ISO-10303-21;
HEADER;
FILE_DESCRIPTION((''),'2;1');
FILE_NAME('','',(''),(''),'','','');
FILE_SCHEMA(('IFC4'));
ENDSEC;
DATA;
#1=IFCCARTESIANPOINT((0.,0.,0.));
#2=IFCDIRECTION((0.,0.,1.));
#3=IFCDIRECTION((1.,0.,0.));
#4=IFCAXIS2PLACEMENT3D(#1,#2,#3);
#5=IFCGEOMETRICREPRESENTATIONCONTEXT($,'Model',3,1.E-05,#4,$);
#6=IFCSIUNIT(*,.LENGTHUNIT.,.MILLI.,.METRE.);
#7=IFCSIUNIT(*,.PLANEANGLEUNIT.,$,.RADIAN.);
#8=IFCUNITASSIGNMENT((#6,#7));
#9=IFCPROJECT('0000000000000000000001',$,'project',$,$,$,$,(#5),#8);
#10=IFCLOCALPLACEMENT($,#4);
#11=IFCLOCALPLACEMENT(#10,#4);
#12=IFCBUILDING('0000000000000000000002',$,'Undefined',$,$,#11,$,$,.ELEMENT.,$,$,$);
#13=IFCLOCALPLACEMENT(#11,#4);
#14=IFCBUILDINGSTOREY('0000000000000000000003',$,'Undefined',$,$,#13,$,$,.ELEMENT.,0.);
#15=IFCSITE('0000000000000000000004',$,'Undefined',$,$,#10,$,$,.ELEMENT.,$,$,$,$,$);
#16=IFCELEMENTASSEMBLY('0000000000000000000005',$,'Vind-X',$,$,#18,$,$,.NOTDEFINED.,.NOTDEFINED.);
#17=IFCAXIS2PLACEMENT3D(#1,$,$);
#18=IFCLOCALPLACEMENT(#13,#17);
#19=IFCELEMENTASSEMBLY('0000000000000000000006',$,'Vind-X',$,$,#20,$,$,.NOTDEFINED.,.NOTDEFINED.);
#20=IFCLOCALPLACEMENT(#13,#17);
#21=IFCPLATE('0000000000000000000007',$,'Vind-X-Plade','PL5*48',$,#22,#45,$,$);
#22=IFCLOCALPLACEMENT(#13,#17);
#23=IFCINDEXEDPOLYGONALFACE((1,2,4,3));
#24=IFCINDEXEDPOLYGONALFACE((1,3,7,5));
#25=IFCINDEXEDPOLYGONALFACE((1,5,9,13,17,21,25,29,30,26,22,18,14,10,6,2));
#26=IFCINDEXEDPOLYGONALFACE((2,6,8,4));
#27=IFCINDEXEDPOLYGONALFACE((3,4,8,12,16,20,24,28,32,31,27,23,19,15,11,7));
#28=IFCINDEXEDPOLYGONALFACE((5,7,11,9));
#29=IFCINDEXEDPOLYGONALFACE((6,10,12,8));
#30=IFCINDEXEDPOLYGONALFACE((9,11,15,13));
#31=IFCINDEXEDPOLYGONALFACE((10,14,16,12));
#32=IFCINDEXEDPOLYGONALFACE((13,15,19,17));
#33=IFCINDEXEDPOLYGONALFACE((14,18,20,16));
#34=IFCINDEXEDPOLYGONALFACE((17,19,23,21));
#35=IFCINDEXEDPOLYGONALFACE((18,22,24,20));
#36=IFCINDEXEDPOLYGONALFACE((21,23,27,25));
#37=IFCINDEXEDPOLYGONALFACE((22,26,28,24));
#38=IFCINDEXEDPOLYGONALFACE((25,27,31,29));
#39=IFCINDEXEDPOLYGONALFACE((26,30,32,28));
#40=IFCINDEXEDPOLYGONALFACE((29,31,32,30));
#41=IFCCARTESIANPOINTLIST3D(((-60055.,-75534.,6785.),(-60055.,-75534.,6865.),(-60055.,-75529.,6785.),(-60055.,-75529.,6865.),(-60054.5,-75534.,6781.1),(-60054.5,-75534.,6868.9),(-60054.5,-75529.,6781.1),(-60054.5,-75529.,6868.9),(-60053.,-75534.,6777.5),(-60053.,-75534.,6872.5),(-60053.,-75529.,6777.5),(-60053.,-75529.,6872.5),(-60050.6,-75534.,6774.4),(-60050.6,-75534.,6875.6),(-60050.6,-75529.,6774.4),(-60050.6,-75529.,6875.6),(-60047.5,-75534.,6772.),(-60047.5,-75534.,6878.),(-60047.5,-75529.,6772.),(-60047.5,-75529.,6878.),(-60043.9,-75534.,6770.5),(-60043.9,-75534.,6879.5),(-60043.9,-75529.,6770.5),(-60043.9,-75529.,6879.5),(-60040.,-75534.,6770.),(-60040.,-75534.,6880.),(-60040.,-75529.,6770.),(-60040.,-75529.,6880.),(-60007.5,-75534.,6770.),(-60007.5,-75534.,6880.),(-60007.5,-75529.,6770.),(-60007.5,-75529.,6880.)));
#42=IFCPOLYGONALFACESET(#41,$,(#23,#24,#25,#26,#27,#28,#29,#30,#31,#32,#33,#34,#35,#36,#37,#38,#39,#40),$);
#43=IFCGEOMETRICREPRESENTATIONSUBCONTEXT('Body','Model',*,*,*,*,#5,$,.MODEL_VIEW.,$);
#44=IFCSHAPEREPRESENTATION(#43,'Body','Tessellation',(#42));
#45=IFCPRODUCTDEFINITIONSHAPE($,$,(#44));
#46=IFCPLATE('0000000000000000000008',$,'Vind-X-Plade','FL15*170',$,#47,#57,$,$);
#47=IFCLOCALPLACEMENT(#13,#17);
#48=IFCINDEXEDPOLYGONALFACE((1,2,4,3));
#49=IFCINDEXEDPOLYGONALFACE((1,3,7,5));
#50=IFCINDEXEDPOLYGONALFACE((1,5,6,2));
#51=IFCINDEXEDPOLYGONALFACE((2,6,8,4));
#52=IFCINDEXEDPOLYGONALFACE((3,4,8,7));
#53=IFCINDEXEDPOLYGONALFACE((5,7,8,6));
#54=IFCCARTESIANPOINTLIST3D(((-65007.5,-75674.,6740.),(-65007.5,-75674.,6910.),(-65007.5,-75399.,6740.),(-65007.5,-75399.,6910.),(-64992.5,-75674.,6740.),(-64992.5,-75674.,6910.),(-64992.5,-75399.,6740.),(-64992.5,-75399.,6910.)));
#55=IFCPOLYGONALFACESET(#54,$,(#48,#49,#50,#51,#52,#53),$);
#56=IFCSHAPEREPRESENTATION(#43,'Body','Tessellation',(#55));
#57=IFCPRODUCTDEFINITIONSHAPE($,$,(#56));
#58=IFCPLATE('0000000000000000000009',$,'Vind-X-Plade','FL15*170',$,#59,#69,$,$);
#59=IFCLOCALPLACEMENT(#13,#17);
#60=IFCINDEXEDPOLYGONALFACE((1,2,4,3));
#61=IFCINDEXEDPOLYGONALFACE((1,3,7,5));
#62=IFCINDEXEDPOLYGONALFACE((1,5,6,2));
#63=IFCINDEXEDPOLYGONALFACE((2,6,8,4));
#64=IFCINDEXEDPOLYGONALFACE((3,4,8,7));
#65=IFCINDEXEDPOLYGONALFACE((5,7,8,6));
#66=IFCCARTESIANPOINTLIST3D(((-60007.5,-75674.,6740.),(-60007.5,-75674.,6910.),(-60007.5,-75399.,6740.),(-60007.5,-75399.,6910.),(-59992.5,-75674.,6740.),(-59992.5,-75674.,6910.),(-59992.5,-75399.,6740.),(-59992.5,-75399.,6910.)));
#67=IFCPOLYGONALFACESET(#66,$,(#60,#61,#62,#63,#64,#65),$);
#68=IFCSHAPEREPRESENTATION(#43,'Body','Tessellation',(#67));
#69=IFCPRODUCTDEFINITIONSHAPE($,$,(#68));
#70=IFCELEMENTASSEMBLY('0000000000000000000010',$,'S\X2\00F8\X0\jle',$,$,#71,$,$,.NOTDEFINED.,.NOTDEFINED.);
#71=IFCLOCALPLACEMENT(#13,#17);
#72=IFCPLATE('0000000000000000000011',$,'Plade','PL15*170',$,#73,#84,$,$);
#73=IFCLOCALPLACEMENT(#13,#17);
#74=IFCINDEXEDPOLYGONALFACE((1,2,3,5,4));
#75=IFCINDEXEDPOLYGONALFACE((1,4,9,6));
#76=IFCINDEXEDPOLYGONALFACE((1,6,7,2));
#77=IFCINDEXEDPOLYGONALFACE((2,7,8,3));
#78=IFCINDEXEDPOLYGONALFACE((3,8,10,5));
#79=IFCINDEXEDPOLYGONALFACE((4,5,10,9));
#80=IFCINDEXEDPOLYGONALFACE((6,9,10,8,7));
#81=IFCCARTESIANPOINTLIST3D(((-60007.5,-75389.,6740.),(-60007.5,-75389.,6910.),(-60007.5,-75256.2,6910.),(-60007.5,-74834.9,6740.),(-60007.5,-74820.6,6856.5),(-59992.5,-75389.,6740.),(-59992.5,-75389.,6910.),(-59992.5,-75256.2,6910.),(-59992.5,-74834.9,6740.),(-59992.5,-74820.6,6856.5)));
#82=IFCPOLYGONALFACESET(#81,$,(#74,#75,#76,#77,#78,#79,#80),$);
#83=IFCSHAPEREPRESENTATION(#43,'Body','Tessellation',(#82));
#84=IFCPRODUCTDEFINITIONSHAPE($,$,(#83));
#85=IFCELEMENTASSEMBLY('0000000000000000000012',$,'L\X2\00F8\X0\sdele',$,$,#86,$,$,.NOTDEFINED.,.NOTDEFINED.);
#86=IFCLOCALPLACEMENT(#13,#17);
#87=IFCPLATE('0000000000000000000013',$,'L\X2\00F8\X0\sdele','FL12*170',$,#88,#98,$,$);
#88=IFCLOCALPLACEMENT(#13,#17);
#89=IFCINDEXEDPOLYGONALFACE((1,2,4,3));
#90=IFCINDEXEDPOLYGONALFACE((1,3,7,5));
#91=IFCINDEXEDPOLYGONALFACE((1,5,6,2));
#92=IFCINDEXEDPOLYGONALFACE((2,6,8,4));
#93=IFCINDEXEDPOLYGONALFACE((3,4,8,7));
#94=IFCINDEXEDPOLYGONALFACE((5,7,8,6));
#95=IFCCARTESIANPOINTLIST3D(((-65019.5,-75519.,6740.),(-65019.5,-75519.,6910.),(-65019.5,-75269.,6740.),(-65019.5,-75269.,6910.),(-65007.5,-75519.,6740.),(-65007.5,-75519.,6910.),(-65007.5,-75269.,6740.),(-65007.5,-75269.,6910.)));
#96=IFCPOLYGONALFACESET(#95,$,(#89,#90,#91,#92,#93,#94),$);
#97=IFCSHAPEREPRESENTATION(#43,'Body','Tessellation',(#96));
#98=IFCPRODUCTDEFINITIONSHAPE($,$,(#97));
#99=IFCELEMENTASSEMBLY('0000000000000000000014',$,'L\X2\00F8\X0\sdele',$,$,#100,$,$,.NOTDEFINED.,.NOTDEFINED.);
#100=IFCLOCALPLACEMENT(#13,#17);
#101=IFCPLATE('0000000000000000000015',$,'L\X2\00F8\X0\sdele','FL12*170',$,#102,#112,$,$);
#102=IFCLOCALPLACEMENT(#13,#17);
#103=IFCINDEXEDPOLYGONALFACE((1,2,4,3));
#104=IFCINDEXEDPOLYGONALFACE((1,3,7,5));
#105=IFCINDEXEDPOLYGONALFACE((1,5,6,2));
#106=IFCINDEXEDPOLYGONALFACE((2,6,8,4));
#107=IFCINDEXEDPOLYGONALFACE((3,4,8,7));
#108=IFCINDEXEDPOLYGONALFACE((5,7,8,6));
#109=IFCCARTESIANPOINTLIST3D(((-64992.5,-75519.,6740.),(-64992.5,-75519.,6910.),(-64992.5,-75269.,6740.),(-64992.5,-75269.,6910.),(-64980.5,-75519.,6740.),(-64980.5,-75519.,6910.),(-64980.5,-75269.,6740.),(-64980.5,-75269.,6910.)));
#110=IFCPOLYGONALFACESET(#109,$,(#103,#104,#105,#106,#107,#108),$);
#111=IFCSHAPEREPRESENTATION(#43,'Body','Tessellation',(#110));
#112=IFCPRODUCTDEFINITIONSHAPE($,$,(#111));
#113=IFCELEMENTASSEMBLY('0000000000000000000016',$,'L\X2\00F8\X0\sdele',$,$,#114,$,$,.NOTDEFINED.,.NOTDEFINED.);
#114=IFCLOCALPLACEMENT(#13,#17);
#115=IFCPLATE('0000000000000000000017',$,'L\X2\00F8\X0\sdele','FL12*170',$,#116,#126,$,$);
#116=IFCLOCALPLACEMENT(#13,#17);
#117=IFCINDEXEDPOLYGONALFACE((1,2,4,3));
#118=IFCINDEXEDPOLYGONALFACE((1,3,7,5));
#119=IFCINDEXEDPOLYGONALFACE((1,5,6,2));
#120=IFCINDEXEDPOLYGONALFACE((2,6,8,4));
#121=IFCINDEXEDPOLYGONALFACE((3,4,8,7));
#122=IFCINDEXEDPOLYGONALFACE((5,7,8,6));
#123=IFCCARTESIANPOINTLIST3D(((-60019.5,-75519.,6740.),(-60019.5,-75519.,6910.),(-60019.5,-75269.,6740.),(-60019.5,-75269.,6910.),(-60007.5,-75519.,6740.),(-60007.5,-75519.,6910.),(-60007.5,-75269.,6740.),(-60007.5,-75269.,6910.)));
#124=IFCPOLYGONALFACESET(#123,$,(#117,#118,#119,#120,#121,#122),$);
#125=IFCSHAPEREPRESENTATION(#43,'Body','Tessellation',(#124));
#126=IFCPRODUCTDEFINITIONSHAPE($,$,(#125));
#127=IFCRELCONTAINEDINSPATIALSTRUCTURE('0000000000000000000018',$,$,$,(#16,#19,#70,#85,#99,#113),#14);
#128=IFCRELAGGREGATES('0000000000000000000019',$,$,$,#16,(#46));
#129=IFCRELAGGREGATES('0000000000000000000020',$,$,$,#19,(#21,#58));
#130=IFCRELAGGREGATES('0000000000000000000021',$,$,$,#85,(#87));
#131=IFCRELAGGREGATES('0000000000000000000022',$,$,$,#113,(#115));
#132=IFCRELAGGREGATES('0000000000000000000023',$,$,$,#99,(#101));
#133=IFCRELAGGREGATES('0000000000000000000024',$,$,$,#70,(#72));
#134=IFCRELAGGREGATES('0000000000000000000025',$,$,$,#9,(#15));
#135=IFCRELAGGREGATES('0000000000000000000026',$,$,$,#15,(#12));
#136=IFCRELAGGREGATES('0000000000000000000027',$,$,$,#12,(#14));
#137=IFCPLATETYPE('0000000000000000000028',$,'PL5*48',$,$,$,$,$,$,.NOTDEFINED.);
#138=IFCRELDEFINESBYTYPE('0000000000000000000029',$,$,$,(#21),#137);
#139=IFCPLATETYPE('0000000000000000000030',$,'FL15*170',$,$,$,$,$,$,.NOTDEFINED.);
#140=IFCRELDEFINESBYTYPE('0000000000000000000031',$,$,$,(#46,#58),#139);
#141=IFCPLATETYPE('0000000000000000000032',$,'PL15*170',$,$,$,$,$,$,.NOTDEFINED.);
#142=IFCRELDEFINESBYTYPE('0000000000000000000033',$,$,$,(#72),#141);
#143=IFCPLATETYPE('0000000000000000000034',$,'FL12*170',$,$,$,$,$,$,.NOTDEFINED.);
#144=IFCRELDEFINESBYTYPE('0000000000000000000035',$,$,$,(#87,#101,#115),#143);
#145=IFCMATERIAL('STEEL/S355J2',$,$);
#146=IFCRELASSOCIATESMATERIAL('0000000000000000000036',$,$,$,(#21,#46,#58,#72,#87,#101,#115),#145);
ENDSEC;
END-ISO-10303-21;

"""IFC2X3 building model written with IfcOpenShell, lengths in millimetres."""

from ifc_helpers import new_model, si_unit, frame, frame_2d, origin_with_axes, place, context, subcontext, project, spatial, polyline, circle_curve, parameter, trimmed, segment, composite_curve, outline, extrude, material, type_object, element, aggregate, save


model = new_model("IFC2X3")

# Units and contexts
model_context = context("Model", 3, precision=1e-05, world=origin_with_axes())
body_context = subcontext(model_context, "Body", "Model", "MODEL_VIEW")
ifc_project = project(units=[si_unit("LENGTHUNIT", "METRE", prefix="MILLI"), si_unit("PLANEANGLEUNIT", "RADIAN")], contexts=[model_context])

# Site, building, storey
site_placement = place(None, origin_with_axes())
site = spatial("IfcSite", under=ifc_project, at=site_placement, Name="Undefined", CompositionType="ELEMENT")
building_placement = place(site_placement, origin_with_axes())
building = spatial("IfcBuilding", under=site, at=building_placement, Name="Undefined", CompositionType="ELEMENT")
storey_placement = place(building_placement, origin_with_axes())
storey = spatial("IfcBuildingStorey", under=building, at=storey_placement, Name="Undefined", CompositionType="ELEMENT", Elevation=0.0)

# Element assemblies
assembly_1_placement = place(storey_placement, origin_with_axes())
assembly_1 = element("IfcElementAssembly", 1, at=assembly_1_placement, inside=storey, Name="Vind-X", AssemblyPlace="NOTDEFINED", PredefinedType="NOTDEFINED")
assembly_2_placement = place(storey_placement, origin_with_axes())
assembly_2 = element("IfcElementAssembly", 2, at=assembly_2_placement, inside=storey, Name="Vind-X", AssemblyPlace="NOTDEFINED", PredefinedType="NOTDEFINED")

# Shared definitions
ifc_material_1 = material(Name="STEEL/S355J2")

# Plates
plate_type_1 = type_object("IfcPlateType", Name="PL5*48", PredefinedType="NOTDEFINED")
plate_1_placement = place(assembly_2_placement, frame((-60007.5, -75531.5, 6880.0), z_axis=(0.0, -1.0, 0.0), x_axis=(-1.0, 0.0, 0.0)))
plate_1 = element("IfcPlate", 3, at=plate_1_placement, type_object=plate_type_1, material=ifc_material_1, Name="Vind-X-Plade", Description="PL5*48", context=body_context, shape_type="SweptSolid", body=[
    extrude(outline(composite_curve([segment(polyline([(0.0, 0.0), (32.5, 0.0)]), True, "CONTINUOUS"), segment(trimmed(circle_curve(frame_2d((32.5, 15.0), x_axis=(0.0, -1.0)), 15.0), [parameter(0.0)], [parameter(1.570796)], True, "PARAMETER"), True, "CONTINUOUS"), segment(polyline([(47.5, 15.0), (47.5, 95.0)]), True, "CONTINUOUS"), segment(trimmed(circle_curve(frame_2d((32.5, 95.0), x_axis=(1.0, 0.0)), 15.0), [parameter(0.0)], [parameter(1.570796)], True, "PARAMETER"), True, "CONTINUOUS"), segment(polyline([(32.5, 110.0), (0.0, 110.0), (0.0, 0.0)]), True, "CONTINUOUS")], self_intersect=True)), frame((0.0, 0.0, -2.5), z_axis=(0.0, 0.0, 1.0), x_axis=(1.0, 0.0, 0.0)), (0.0, 0.0, 1.0), 5.0),
])
plate_type_2 = type_object("IfcPlateType", Name="FL15*170", PredefinedType="NOTDEFINED")
plate_2_placement = place(assembly_1_placement, frame((-65000.0, -75399.0, 6825.0), z_axis=(1.0, 0.0, 0.0), x_axis=(0.0, -1.0, 0.0)))
plate_2 = element("IfcPlate", 4, at=plate_2_placement, type_object=plate_type_2, material=ifc_material_1, Name="Vind-X-Plade", Description="FL15*170", context=body_context, shape_type="SweptSolid", body=[
    extrude(outline(polyline([(0.0, -85.0), (0.0, 85.0), (275.0, 85.0), (275.0, -85.0), (0.0, -85.0)])), frame((0.0, 0.0, -7.5), z_axis=(0.0, 0.0, 1.0), x_axis=(1.0, 0.0, 0.0)), (0.0, 0.0, 1.0), 15.0),
])
aggregate(assembly_1, [plate_2])
plate_3_placement = place(assembly_2_placement, frame((-60000.0, -75399.0, 6825.0), z_axis=(1.0, 0.0, 0.0), x_axis=(0.0, -1.0, 0.0)))
plate_3 = element("IfcPlate", 5, at=plate_3_placement, type_object=plate_type_2, material=ifc_material_1, Name="Vind-X-Plade", Description="FL15*170", context=body_context, shape_type="SweptSolid", body=[
    extrude(outline(polyline([(0.0, -85.0), (0.0, 85.0), (275.0, 85.0), (275.0, -85.0), (0.0, -85.0)])), frame((0.0, 0.0, -7.5), z_axis=(0.0, 0.0, 1.0), x_axis=(1.0, 0.0, 0.0)), (0.0, 0.0, 1.0), 15.0),
])
aggregate(assembly_2, [plate_1, plate_3])

# Element assemblies, plates
assembly_3_placement = place(storey_placement, origin_with_axes())
assembly_3 = element("IfcElementAssembly", 6, at=assembly_3_placement, inside=storey, Name="Søjle", AssemblyPlace="NOTDEFINED", PredefinedType="NOTDEFINED")
plate_type_3 = type_object("IfcPlateType", Name="PL15*170", PredefinedType="NOTDEFINED")
plate_4_placement = place(assembly_3_placement, frame((-60000.0, -74834.9, 6740.0), z_axis=(1.0, 0.0, 0.0), x_axis=(0.0, 0.121869, 0.992546)))
plate_4 = element("IfcPlate", 7, at=plate_4_placement, type_object=plate_type_3, material=ifc_material_1, Name="Plade", Description="PL15*170", context=body_context, shape_type="SweptSolid", body=[
    extrude(outline(polyline([(0.0, 0.0), (117.4, 0.0), (117.4, 438.9), (101.2, 570.7), (-67.5, 550.0), (0.0, 0.0)])), frame((0.0, 0.0, -7.5), z_axis=(0.0, 0.0, 1.0), x_axis=(1.0, 0.0, 0.0)), (0.0, 0.0, 1.0), 15.0),
])
assembly_4_placement = place(storey_placement, origin_with_axes())
assembly_4 = element("IfcElementAssembly", 8, at=assembly_4_placement, inside=storey, Name="Løsdele", AssemblyPlace="NOTDEFINED", PredefinedType="NOTDEFINED")
plate_type_4 = type_object("IfcPlateType", Name="FL12*170", PredefinedType="NOTDEFINED")
plate_5_placement = place(assembly_4_placement, frame((-65013.5, -75269.0, 6825.0), z_axis=(-1.0, 0.0, 0.0), x_axis=(0.0, -1.0, 0.0)))
plate_5 = element("IfcPlate", 9, at=plate_5_placement, type_object=plate_type_4, material=ifc_material_1, Name="Løsdele", Description="FL12*170", context=body_context, shape_type="SweptSolid", body=[
    extrude(outline(polyline([(0.0, -85.0), (0.0, 85.0), (250.0, 85.0), (250.0, -85.0), (0.0, -85.0)])), frame((0.0, 0.0, -6.0), z_axis=(0.0, 0.0, 1.0), x_axis=(1.0, 0.0, 0.0)), (0.0, 0.0, 1.0), 12.0),
])
aggregate(assembly_4, [plate_5])
assembly_5_placement = place(storey_placement, origin_with_axes())
assembly_5 = element("IfcElementAssembly", 10, at=assembly_5_placement, inside=storey, Name="Løsdele", AssemblyPlace="NOTDEFINED", PredefinedType="NOTDEFINED")
plate_6_placement = place(assembly_5_placement, frame((-64986.5, -75269.0, 6825.0), z_axis=(-1.0, 0.0, 0.0), x_axis=(0.0, -1.0, 0.0)))
plate_6 = element("IfcPlate", 11, at=plate_6_placement, type_object=plate_type_4, material=ifc_material_1, Name="Løsdele", Description="FL12*170", context=body_context, shape_type="SweptSolid", body=[
    extrude(outline(polyline([(0.0, -85.0), (0.0, 85.0), (250.0, 85.0), (250.0, -85.0), (0.0, -85.0)])), frame((0.0, 0.0, -6.0), z_axis=(0.0, 0.0, 1.0), x_axis=(1.0, 0.0, 0.0)), (0.0, 0.0, 1.0), 12.0),
])
assembly_6_placement = place(storey_placement, origin_with_axes())
assembly_6 = element("IfcElementAssembly", 12, at=assembly_6_placement, inside=storey, Name="Løsdele", AssemblyPlace="NOTDEFINED", PredefinedType="NOTDEFINED")
plate_7_placement = place(assembly_6_placement, frame((-60013.5, -75269.0, 6825.0), z_axis=(-1.0, 0.0, 0.0), x_axis=(0.0, -1.0, 0.0)))
plate_7 = element("IfcPlate", 13, at=plate_7_placement, type_object=plate_type_4, material=ifc_material_1, Name="Løsdele", Description="FL12*170", context=body_context, shape_type="SweptSolid", body=[
    extrude(outline(polyline([(0.0, -85.0), (0.0, 85.0), (250.0, 85.0), (250.0, -85.0), (0.0, -85.0)])), frame((0.0, 0.0, -6.0), z_axis=(0.0, 0.0, 1.0), x_axis=(1.0, 0.0, 0.0)), (0.0, 0.0, 1.0), 12.0),
])
aggregate(assembly_6, [plate_7])

aggregate(assembly_5, [plate_6])

aggregate(assembly_3, [plate_4])

save(model, "model.ifc")
